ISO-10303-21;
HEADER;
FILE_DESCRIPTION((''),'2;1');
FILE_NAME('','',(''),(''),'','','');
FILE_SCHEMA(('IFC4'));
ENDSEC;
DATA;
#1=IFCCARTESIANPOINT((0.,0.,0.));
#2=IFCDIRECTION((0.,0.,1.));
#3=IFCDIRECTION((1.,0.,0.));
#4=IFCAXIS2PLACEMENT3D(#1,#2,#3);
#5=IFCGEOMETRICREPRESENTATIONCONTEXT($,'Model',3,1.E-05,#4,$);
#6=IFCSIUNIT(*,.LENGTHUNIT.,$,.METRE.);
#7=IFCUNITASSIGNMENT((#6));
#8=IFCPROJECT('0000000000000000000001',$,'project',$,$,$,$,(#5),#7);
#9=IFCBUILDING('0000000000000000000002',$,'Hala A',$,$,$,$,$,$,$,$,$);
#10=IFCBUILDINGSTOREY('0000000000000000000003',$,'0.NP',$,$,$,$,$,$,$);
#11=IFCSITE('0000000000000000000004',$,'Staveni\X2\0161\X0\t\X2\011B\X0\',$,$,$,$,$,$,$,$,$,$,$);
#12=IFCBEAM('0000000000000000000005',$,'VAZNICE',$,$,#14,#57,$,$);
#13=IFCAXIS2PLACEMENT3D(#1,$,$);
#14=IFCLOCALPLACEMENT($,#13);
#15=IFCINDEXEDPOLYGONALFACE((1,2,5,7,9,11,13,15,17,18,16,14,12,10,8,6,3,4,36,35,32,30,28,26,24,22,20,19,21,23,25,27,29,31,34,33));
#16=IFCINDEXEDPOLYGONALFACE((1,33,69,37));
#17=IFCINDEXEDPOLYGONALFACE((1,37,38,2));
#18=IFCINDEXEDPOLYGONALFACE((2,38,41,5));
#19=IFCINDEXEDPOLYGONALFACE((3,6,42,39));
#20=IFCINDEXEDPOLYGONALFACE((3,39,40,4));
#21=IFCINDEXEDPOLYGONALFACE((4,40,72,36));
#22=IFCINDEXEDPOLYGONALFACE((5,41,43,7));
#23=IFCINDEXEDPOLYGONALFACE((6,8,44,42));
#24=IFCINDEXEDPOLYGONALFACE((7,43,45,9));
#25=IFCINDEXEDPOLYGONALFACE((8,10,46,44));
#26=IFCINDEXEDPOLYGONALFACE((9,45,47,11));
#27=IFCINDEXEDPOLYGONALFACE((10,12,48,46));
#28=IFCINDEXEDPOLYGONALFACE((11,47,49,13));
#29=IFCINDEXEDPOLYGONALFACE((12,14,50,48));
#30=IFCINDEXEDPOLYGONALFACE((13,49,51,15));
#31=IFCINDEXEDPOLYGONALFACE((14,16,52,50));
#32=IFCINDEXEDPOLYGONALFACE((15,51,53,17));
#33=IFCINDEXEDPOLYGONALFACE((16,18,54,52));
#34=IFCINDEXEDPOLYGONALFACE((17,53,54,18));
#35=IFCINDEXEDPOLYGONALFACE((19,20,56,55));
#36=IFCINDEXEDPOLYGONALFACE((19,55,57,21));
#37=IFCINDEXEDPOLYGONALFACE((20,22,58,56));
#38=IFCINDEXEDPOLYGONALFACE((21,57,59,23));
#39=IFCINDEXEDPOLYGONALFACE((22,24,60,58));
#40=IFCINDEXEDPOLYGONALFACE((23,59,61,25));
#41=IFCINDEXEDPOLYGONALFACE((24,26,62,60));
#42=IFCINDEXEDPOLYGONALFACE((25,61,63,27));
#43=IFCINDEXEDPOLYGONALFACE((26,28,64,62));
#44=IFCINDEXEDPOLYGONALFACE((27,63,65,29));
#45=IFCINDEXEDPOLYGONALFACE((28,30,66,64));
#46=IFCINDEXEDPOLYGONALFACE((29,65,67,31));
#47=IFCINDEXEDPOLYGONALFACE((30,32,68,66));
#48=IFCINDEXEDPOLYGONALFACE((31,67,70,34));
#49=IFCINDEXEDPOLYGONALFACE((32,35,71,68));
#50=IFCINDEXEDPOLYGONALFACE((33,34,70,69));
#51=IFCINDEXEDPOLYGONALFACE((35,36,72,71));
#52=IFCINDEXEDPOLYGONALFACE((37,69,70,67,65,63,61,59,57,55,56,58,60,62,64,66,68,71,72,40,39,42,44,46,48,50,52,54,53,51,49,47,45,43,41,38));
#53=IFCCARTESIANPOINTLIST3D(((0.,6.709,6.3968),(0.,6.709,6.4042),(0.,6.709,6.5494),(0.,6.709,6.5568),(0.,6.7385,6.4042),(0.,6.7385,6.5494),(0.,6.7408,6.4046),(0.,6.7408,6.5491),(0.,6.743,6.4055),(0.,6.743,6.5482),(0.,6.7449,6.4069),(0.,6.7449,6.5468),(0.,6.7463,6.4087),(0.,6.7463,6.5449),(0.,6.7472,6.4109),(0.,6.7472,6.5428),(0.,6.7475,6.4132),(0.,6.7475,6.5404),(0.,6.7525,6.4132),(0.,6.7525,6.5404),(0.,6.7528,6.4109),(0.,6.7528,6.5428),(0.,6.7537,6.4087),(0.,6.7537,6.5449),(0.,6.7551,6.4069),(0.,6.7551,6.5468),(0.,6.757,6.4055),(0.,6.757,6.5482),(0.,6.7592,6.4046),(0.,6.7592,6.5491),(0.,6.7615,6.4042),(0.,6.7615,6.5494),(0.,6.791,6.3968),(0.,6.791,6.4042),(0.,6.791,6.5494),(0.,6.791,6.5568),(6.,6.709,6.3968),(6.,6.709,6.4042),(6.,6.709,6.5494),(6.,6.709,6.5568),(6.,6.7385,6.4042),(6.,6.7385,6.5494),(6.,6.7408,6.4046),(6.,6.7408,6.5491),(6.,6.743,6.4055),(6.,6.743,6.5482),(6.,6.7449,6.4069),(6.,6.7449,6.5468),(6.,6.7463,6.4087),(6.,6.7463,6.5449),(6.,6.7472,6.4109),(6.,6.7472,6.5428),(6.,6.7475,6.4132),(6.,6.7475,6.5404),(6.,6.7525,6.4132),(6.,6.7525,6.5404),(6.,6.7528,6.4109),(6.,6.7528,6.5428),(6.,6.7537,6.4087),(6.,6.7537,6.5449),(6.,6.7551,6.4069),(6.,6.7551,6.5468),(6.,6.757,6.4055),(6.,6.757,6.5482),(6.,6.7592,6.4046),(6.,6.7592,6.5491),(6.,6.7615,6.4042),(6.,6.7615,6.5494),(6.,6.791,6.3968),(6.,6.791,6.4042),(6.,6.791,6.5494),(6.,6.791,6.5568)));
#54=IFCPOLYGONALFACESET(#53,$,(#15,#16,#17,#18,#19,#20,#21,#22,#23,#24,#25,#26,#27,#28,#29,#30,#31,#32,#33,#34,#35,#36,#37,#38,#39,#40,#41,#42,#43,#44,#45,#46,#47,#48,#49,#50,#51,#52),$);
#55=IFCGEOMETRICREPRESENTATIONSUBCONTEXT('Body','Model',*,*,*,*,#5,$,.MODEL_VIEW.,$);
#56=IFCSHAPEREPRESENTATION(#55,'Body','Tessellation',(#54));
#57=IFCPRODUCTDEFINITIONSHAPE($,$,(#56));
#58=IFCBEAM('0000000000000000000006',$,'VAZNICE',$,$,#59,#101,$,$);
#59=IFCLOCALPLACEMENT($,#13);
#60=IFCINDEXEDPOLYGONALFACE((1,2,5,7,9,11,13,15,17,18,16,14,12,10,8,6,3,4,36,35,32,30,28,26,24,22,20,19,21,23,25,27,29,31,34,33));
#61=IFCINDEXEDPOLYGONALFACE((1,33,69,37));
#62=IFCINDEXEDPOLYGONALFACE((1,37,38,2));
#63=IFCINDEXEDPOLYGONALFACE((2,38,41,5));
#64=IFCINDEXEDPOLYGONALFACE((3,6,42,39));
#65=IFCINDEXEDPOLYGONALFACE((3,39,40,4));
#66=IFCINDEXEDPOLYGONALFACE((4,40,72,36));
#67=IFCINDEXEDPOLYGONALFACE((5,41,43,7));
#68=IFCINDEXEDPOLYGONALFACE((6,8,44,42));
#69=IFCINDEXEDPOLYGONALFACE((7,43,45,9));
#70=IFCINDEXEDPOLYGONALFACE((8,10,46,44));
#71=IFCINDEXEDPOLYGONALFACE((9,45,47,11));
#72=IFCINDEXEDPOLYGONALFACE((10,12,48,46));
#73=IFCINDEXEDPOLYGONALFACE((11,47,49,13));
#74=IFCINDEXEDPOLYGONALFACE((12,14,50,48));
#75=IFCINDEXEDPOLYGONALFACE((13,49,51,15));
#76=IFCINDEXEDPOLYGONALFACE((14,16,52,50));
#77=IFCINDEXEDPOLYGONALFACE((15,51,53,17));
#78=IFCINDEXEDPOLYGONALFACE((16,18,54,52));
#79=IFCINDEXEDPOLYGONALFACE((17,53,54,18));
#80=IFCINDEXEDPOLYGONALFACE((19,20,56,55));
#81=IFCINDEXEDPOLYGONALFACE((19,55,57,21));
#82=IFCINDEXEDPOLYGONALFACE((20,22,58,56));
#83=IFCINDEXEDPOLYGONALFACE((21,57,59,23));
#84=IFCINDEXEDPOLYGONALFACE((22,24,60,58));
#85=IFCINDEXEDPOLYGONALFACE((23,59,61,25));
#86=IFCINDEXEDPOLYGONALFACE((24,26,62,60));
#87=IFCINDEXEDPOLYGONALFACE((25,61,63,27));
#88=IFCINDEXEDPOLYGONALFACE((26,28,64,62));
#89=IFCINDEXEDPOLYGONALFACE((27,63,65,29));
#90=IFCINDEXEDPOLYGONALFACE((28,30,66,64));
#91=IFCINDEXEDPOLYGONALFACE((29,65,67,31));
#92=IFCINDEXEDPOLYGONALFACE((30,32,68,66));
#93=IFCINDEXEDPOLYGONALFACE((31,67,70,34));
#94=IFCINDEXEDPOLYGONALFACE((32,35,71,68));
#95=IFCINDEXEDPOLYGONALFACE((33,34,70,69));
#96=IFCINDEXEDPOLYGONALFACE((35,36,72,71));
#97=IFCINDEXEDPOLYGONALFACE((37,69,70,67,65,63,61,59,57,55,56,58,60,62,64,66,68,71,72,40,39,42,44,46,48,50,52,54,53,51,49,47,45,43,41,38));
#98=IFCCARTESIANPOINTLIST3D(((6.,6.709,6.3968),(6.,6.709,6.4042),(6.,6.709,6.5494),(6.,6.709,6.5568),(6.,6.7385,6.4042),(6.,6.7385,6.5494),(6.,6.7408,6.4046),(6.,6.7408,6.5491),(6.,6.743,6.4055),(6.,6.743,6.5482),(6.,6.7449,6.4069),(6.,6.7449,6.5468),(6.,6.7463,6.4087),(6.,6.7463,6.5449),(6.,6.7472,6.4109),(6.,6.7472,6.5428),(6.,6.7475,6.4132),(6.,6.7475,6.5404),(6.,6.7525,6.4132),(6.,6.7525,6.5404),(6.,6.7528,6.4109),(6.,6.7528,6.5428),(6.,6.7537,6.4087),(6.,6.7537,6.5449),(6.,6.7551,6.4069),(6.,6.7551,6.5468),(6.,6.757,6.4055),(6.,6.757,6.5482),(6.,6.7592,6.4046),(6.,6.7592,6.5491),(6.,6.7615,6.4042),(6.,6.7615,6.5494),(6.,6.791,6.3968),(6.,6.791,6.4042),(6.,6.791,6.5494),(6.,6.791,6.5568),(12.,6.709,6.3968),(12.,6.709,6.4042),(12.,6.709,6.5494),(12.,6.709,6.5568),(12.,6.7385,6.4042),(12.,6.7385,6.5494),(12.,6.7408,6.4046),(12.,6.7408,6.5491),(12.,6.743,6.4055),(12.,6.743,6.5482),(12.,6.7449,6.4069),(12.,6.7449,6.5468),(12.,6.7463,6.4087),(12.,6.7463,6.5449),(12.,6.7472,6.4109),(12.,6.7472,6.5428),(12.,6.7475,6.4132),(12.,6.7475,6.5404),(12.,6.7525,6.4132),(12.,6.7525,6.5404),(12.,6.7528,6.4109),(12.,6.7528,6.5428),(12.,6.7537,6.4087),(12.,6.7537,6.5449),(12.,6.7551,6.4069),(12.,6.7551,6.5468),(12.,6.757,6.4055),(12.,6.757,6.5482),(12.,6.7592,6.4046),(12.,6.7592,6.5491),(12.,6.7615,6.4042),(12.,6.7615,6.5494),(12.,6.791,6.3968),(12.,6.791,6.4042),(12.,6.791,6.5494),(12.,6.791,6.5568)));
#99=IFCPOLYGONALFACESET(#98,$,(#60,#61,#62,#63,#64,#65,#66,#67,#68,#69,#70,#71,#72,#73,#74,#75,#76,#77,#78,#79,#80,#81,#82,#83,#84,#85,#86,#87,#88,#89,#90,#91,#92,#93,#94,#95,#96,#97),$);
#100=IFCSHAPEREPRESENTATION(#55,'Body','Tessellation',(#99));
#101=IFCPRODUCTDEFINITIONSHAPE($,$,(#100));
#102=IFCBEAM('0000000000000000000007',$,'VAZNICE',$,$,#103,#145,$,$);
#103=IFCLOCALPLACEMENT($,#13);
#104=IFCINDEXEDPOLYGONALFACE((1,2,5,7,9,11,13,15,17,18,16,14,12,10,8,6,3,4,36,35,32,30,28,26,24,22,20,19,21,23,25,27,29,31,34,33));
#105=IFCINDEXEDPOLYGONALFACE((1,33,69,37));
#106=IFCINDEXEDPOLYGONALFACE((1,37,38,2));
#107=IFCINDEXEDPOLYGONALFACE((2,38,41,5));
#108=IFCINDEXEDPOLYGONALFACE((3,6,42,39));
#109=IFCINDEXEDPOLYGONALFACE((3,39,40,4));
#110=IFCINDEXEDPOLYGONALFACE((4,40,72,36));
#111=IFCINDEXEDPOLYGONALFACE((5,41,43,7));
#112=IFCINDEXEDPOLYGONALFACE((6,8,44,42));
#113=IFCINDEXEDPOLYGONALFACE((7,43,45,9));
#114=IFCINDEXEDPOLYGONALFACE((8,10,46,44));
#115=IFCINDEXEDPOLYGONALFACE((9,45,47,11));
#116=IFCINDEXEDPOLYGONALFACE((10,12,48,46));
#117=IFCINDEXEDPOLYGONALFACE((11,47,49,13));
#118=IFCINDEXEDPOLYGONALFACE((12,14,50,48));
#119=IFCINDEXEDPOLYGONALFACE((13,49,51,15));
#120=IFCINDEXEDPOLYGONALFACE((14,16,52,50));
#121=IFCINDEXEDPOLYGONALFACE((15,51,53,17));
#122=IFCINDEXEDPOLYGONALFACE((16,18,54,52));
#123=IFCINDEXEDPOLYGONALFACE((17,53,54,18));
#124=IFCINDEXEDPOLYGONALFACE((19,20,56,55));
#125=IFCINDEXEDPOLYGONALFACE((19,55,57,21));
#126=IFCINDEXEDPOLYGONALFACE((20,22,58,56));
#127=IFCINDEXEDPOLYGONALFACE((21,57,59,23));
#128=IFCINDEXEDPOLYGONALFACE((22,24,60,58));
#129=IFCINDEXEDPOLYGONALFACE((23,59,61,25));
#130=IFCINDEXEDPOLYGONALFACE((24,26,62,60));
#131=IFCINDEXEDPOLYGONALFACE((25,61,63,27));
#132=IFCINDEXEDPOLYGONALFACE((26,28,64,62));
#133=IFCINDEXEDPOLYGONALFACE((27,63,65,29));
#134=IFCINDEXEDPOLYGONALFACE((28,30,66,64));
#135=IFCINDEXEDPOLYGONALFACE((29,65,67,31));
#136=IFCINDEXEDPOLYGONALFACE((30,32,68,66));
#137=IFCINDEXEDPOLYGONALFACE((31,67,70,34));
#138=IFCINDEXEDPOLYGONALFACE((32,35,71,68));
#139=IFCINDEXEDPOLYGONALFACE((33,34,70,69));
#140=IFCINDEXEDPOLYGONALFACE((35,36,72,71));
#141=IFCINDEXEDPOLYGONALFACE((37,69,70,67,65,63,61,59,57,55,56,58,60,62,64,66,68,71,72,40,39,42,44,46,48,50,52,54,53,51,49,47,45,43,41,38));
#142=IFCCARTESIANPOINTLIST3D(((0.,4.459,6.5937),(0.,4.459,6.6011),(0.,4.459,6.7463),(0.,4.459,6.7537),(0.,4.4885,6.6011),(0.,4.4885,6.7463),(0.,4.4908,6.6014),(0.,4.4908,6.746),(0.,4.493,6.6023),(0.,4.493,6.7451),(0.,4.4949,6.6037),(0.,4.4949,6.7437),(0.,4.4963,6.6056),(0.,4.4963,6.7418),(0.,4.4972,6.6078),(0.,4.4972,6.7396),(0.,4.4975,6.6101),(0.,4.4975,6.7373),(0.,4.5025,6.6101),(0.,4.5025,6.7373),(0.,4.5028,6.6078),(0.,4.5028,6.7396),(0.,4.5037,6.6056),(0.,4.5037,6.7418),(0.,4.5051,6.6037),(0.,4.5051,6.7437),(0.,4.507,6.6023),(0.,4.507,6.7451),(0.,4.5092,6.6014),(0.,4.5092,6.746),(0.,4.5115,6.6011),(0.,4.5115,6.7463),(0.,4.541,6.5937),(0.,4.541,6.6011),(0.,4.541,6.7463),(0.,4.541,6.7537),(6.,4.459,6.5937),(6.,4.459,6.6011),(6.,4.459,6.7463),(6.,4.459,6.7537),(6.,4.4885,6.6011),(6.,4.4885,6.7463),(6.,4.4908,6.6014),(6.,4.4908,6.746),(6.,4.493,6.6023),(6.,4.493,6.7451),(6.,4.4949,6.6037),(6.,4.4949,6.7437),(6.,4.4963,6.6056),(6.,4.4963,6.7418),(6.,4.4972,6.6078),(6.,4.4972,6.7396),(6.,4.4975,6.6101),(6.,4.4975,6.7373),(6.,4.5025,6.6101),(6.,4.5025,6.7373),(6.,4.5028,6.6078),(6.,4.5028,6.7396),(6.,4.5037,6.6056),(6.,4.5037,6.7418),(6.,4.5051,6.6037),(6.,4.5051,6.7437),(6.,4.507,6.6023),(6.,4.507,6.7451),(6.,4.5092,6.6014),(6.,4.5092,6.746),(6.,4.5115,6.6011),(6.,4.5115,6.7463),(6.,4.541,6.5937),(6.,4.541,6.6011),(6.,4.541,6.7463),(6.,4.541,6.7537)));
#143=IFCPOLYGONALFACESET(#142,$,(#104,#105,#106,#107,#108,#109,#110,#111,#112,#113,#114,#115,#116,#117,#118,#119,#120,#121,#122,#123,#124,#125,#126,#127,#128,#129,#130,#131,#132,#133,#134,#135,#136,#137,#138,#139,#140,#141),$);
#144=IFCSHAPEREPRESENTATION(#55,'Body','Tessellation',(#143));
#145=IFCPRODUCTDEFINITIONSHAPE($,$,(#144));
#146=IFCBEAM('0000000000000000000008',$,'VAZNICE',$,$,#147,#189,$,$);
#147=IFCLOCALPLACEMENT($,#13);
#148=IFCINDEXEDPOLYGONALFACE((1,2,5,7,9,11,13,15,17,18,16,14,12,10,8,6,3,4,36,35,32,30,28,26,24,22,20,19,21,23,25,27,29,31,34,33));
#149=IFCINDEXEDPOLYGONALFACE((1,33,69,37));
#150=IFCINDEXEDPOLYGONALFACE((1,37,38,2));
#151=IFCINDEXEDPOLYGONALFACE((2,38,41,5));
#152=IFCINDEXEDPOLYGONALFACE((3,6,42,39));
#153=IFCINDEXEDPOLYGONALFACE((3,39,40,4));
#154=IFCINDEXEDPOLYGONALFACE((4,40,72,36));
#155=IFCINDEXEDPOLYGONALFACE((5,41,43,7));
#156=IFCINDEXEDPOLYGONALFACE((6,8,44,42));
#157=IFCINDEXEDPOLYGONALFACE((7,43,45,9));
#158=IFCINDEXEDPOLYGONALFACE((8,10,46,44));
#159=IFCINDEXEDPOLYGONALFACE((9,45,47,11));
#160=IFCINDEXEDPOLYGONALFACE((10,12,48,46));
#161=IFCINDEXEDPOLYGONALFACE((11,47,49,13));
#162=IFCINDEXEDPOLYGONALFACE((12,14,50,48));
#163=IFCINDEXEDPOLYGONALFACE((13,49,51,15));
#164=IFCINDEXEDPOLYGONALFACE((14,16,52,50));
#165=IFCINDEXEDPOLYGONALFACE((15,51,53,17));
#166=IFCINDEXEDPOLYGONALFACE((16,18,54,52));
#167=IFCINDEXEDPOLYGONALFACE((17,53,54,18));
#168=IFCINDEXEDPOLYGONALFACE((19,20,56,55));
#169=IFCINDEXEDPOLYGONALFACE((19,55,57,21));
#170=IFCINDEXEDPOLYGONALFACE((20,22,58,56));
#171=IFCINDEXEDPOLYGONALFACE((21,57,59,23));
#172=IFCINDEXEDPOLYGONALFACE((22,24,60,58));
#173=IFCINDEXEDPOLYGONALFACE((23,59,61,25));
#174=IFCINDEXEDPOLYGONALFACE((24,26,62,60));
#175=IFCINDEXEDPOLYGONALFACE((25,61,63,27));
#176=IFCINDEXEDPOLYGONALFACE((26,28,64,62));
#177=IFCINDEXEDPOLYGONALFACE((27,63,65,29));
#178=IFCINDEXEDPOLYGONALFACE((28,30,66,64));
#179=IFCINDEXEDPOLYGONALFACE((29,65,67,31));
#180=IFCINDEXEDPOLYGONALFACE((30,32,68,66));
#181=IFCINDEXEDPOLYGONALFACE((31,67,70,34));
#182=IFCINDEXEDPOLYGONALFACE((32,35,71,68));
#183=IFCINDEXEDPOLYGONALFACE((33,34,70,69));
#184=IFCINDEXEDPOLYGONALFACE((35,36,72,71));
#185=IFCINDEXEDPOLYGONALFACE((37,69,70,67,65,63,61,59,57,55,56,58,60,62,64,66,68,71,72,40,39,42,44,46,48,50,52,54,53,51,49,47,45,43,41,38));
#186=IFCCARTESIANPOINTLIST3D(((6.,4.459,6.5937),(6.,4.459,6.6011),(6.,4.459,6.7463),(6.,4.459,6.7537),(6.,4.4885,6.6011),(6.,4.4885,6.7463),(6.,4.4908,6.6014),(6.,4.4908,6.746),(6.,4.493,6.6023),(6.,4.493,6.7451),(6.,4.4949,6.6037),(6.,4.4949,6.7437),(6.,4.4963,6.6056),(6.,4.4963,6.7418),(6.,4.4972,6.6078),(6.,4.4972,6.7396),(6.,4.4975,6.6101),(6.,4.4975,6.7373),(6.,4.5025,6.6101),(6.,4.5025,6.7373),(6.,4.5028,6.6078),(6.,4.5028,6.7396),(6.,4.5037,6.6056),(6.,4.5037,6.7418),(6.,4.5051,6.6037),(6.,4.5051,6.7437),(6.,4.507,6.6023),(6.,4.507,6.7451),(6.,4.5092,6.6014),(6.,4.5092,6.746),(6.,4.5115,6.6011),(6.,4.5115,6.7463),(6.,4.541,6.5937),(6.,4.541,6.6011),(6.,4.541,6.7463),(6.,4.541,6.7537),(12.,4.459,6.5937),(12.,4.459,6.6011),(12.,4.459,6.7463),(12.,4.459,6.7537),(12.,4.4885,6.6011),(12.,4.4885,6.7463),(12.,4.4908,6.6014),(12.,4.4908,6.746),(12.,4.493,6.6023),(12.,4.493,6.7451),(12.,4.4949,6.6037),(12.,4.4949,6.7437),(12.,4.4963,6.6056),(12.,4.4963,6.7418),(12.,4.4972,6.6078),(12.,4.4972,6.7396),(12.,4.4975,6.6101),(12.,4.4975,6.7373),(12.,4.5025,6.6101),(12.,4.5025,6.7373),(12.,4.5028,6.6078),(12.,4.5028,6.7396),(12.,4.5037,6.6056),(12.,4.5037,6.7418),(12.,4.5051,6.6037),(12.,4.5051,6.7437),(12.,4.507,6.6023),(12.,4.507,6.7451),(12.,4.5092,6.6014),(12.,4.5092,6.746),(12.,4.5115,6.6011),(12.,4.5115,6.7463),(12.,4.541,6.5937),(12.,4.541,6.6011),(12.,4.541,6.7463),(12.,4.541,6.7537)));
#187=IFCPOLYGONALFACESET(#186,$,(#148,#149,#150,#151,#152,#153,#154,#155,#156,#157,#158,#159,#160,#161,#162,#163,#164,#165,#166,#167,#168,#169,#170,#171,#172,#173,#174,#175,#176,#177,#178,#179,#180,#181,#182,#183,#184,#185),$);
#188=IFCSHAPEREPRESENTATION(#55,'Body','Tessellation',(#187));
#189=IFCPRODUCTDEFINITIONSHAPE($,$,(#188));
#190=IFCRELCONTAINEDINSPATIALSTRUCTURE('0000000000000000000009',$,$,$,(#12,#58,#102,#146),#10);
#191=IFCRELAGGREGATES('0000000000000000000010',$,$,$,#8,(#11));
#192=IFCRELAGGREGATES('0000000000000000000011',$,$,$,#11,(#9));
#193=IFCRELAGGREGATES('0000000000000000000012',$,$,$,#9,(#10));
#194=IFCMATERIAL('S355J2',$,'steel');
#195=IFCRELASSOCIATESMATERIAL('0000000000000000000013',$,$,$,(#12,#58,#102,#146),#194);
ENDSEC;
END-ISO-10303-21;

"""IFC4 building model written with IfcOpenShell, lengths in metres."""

from ifc_helpers import new_model, si_unit, frame, origin_with_axes, place, context, subcontext, project, spatial, i_section, extrude, material, element, save


model = new_model("IFC4")

# Units and contexts
model_context = context("Model", 3, precision=1e-05, world=origin_with_axes())
body_context = subcontext(model_context, "Body", "Model", "MODEL_VIEW")
ifc_project = project(units=[si_unit("LENGTHUNIT", "METRE")], contexts=[model_context])

# Site, building, storey
site = spatial("IfcSite", under=ifc_project, Name="Staveniště")
building = spatial("IfcBuilding", under=site, Name="Hala A")
storey = spatial("IfcBuildingStorey", under=building, Name="0.NP")

# Shared definitions
ifc_material = material(Name="S355J2", Category="steel")

# Beams
for number, where, z_axis, x_axis, name in (
    (1, (0.0, 6.75, 6.4768), (1.0, 0.0, 0.0), (0.0, 1.0, 0.0), "VAZNICE"),
    (2, (6.0, 6.75, 6.4768), (1.0, 0.0, 0.0), (0.0, 1.0, 0.0), "VAZNICE"),
    (3, (0.0, 4.5, 6.6737), (1.0, 0.0, 0.0), (0.0, 1.0, 0.0), "VAZNICE"),
    (4, (6.0, 4.5, 6.6737), (1.0, 0.0, 0.0), (0.0, 1.0, 0.0), "VAZNICE"),
):
    element("IfcBeam", number, at=place(None, frame(where, z_axis=z_axis, x_axis=x_axis)), inside=storey, material=ifc_material, Name=name, context=body_context, shape_type="SweptSolid", body=[
        extrude(i_section(OverallWidth=0.082, OverallDepth=0.16, WebThickness=0.005, FlangeThickness=0.0074, FilletRadius=0.009), origin_with_axes(), (0.0, 0.0, 1.0), 6.0),
    ])

save(model, "model.ifc")
